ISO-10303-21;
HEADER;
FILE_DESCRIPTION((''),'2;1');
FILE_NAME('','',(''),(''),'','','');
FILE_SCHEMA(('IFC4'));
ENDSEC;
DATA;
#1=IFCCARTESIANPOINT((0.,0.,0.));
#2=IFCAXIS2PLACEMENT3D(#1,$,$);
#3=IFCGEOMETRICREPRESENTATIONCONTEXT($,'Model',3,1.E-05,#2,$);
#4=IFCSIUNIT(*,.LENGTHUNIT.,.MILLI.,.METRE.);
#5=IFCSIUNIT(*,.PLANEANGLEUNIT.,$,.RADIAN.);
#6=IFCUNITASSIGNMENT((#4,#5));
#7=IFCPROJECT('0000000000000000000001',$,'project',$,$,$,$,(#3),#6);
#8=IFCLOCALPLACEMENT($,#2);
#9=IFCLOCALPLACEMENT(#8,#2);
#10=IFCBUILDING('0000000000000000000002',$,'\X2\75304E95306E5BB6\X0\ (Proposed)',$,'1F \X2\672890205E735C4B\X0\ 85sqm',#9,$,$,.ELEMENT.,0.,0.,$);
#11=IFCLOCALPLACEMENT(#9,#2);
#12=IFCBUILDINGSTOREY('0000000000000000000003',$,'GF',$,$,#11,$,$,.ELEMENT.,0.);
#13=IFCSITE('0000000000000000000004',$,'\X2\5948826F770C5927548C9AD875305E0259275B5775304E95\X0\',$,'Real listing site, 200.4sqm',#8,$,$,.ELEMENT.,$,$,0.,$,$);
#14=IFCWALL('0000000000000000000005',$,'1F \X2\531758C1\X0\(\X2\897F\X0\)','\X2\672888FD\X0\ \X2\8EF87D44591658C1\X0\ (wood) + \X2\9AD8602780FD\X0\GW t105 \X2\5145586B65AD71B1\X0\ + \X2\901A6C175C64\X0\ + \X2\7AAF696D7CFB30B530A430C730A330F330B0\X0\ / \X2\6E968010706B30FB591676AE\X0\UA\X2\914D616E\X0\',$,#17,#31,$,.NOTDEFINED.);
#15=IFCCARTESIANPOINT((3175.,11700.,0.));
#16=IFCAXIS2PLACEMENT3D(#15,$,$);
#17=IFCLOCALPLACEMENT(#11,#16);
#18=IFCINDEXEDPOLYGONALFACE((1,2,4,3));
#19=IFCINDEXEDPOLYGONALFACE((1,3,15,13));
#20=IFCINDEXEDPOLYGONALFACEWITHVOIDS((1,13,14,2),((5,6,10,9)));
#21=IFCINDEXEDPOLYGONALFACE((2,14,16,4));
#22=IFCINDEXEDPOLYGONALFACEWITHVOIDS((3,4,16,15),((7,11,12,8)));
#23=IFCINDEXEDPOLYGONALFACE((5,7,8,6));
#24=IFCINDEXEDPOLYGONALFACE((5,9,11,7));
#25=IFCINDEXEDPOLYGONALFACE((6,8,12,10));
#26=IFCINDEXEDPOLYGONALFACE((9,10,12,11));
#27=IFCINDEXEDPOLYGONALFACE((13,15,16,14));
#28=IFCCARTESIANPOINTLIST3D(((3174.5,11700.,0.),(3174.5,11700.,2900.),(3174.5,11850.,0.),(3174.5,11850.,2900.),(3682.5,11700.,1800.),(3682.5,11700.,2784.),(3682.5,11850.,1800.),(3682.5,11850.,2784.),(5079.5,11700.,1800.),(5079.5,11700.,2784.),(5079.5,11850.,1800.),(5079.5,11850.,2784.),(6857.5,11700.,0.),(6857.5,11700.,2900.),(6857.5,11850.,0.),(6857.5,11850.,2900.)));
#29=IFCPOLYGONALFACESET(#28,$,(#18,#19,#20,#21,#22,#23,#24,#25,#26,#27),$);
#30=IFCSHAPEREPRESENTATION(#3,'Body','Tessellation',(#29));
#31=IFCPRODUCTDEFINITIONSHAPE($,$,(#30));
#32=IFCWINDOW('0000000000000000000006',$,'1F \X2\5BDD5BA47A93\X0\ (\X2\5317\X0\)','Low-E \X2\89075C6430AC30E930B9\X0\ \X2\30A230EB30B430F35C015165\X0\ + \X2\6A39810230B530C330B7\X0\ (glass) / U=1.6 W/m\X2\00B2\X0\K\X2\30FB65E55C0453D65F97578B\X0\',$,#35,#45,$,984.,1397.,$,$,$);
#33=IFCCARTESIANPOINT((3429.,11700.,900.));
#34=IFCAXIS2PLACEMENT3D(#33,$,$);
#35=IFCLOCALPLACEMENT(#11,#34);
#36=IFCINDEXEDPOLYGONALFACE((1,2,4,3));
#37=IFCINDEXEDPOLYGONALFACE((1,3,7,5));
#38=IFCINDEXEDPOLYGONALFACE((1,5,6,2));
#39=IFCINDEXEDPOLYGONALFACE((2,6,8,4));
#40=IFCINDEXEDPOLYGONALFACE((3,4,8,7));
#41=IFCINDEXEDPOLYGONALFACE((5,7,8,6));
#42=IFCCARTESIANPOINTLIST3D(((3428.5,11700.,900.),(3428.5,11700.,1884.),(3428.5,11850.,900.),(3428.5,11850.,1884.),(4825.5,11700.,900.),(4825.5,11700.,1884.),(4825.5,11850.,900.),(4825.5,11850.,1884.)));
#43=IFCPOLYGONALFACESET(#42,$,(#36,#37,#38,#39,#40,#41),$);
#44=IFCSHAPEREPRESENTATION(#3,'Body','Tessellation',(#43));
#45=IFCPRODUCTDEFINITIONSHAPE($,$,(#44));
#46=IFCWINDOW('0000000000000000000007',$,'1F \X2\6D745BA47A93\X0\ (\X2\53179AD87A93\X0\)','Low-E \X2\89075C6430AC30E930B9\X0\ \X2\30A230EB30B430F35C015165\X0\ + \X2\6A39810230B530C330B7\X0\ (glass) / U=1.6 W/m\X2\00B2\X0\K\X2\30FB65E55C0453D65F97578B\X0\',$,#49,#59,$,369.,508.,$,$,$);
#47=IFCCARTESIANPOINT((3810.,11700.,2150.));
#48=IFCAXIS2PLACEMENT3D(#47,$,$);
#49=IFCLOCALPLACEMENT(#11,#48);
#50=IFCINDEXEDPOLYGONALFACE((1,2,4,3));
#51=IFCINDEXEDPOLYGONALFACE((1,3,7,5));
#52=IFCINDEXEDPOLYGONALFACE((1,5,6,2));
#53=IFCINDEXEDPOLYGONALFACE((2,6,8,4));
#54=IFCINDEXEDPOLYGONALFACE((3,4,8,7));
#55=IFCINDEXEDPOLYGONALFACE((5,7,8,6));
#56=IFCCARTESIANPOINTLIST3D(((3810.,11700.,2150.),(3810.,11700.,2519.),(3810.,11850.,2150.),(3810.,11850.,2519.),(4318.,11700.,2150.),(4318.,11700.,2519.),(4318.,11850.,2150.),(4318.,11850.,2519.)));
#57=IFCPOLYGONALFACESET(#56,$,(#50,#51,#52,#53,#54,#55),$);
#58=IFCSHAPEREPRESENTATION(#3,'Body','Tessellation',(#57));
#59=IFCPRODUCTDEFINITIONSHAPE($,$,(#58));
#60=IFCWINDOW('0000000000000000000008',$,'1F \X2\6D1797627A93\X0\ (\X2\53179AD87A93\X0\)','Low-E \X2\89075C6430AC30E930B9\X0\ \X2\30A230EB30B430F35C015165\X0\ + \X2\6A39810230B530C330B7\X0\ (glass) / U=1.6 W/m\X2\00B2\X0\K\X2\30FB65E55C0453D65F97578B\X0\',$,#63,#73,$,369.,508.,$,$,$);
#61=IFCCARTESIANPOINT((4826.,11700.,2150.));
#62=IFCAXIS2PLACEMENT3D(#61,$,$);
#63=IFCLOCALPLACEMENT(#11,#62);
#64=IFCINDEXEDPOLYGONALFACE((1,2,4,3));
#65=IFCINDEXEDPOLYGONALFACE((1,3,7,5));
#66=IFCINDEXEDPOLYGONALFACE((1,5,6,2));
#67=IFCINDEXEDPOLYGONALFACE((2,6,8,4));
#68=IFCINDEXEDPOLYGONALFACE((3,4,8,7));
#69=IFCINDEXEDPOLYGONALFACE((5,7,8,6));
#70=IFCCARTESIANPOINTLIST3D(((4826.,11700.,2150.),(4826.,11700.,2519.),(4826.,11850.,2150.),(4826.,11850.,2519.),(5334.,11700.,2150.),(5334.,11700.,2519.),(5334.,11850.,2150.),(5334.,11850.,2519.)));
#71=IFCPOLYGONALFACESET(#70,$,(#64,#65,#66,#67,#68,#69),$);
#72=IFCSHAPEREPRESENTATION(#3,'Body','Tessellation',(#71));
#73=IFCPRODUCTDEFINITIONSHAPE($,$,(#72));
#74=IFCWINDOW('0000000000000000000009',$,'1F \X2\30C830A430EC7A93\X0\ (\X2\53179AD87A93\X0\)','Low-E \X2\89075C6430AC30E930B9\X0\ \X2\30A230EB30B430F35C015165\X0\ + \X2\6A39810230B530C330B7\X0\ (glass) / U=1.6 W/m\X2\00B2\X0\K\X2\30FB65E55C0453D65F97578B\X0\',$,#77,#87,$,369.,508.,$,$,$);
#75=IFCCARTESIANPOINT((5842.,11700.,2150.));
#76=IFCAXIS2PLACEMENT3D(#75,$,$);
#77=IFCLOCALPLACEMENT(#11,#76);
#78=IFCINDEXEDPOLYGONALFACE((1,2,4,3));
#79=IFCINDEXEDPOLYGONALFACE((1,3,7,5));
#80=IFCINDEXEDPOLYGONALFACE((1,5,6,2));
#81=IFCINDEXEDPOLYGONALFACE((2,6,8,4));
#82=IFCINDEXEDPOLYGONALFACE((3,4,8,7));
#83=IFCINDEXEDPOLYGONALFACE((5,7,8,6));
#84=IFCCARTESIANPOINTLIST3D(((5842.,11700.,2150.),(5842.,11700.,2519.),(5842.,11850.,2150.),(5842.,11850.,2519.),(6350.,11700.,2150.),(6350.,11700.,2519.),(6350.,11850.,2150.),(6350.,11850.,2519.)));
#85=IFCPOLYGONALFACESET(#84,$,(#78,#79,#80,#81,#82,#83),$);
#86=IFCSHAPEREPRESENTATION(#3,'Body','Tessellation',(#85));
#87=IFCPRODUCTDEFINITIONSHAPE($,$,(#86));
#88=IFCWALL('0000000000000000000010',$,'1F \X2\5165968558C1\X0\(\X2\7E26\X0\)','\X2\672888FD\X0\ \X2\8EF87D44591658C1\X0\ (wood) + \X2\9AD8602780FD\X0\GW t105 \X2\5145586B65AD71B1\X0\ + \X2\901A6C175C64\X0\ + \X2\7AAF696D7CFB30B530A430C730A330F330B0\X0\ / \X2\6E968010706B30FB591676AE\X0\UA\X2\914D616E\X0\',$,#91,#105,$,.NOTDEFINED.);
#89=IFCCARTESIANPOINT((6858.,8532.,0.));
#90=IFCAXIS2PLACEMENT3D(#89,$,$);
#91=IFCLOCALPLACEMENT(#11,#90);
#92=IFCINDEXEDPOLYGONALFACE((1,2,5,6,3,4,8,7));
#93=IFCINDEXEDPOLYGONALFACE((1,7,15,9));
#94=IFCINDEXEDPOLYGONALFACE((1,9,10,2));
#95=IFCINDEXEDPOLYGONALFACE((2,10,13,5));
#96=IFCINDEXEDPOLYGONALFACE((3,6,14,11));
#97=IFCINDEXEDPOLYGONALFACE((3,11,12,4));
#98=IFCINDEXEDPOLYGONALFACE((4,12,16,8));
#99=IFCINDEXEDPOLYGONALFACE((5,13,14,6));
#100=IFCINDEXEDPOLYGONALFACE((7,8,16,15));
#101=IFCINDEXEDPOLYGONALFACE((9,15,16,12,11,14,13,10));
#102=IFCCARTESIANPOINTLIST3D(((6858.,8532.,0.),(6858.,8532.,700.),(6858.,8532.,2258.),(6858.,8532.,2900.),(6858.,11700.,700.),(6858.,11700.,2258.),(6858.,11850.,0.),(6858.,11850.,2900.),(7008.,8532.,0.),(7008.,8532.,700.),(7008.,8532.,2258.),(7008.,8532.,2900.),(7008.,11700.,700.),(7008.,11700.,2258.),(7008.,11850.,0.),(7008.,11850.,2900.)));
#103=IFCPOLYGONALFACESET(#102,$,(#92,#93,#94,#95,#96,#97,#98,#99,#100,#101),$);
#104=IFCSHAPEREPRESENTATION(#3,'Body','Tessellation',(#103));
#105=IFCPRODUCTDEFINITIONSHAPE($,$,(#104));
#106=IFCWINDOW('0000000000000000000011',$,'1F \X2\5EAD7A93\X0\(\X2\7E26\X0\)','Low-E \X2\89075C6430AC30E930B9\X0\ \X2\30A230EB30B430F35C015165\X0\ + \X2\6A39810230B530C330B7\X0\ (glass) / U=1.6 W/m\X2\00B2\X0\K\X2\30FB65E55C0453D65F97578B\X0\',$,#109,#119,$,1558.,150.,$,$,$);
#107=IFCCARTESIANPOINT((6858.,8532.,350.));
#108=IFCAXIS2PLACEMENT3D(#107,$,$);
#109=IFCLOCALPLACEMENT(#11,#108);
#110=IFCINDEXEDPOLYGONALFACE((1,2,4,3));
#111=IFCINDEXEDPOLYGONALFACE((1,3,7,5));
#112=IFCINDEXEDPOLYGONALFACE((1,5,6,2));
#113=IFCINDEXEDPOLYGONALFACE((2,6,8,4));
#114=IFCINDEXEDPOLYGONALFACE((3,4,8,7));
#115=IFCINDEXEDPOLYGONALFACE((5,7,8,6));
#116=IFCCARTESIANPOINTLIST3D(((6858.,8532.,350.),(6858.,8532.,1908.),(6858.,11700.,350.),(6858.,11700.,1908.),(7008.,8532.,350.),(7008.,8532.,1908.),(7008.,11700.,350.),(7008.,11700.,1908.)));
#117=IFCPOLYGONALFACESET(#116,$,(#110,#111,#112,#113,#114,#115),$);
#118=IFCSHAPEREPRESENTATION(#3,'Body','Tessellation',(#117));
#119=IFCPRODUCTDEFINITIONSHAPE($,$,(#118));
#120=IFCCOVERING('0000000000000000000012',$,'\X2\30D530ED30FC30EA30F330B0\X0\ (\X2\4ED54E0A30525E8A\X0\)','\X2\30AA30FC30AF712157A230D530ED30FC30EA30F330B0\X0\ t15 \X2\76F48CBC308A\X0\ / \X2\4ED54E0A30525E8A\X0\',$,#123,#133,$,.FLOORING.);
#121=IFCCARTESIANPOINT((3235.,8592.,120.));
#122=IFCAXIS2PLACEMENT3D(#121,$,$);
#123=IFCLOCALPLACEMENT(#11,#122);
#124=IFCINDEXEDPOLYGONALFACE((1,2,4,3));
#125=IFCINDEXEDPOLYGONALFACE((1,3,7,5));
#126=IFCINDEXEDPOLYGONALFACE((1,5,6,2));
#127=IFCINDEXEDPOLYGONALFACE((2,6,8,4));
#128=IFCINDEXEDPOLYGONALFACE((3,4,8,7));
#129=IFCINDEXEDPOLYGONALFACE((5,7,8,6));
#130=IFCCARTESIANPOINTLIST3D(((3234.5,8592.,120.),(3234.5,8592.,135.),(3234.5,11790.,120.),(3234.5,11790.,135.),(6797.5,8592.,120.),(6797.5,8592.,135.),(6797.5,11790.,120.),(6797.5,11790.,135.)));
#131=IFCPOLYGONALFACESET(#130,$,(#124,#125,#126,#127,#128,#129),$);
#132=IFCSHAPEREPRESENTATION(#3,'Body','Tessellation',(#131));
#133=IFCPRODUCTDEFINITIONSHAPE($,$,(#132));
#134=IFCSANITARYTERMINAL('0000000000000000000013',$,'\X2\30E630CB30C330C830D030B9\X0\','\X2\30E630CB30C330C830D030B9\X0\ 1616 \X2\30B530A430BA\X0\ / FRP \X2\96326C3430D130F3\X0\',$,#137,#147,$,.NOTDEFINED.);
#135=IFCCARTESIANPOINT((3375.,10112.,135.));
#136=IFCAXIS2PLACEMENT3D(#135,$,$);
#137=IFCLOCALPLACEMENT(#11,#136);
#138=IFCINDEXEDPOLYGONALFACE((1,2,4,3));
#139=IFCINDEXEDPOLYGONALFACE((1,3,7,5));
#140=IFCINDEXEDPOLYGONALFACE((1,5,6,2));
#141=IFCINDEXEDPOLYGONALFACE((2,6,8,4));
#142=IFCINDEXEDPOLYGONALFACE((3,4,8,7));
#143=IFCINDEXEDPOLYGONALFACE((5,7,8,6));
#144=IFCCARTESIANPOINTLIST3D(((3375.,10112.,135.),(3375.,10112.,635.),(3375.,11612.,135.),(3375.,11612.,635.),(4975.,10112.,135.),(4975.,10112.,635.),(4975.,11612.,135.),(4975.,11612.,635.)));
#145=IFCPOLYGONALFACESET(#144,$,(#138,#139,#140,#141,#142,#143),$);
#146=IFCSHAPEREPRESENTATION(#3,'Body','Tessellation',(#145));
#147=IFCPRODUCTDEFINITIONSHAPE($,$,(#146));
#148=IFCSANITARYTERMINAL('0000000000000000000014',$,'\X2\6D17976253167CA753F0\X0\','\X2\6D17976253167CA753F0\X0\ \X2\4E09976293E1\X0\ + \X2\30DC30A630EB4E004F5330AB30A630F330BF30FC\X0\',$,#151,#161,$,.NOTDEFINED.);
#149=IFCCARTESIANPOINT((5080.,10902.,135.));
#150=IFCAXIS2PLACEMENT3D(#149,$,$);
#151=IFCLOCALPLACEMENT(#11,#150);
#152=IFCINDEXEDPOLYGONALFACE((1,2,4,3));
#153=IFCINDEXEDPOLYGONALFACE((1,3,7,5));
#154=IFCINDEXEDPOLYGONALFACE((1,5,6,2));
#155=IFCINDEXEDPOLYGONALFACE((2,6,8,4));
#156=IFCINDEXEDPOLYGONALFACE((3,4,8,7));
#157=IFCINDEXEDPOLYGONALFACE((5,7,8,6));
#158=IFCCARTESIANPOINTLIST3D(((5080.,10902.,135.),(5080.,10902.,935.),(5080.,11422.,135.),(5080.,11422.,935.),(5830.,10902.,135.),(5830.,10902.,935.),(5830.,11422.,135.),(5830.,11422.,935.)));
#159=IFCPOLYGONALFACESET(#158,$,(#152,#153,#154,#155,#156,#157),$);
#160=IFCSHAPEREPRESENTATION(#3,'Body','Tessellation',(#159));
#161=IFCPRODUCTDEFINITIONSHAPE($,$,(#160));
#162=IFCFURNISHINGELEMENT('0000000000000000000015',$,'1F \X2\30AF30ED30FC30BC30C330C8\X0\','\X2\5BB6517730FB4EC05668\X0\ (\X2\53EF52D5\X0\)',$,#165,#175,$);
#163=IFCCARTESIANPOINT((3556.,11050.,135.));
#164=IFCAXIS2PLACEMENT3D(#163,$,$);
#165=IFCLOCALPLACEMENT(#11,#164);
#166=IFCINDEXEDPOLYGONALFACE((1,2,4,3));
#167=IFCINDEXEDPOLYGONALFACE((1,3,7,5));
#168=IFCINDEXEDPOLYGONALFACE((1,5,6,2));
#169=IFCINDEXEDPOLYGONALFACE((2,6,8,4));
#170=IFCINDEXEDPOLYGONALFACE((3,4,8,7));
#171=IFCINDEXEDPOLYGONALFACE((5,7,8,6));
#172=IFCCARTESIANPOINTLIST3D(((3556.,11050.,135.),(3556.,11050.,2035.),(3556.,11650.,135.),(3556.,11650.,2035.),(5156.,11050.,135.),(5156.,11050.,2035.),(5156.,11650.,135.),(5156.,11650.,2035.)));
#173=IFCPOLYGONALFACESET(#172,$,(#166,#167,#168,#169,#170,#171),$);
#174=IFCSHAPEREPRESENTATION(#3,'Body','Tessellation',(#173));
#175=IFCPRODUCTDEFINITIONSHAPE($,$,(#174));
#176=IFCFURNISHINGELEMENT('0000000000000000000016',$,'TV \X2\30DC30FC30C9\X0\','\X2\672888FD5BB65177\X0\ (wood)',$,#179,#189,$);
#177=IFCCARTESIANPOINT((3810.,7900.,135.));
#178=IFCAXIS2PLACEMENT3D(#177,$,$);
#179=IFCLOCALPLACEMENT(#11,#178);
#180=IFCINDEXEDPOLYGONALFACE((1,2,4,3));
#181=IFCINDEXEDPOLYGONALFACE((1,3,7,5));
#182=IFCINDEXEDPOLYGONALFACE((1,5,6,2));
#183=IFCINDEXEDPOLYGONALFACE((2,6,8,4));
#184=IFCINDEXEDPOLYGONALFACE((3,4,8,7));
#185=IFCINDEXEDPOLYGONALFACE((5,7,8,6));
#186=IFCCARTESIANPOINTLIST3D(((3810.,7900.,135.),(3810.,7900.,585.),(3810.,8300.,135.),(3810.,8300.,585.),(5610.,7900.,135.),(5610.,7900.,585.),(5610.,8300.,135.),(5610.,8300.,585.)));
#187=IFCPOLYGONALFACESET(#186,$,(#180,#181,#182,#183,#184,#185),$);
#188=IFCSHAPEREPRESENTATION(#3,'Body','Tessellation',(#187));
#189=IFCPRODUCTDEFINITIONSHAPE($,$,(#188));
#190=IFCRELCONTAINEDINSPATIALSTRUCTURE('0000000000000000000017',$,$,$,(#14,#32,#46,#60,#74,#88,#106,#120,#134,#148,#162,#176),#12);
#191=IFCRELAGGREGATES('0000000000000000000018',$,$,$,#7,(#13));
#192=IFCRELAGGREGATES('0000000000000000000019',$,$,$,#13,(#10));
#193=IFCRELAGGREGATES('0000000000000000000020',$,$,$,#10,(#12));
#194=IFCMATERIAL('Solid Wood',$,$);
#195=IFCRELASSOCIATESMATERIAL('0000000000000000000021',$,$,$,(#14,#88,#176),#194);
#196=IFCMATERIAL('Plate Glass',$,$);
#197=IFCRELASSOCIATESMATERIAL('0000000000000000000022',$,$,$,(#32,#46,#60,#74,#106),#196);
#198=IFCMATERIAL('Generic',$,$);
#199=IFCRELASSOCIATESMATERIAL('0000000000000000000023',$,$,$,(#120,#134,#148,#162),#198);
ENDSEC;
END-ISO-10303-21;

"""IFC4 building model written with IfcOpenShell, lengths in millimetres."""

from ifc_helpers import new_model, si_unit, frame, frame_2d, origin, place, context, project, spatial, rectangle, extrude, material, element, fill, save


model = new_model("IFC4")

# Units and contexts
model_context = context("Model", 3, precision=1e-05, world=origin())
ifc_project = project(units=[si_unit("LENGTHUNIT", "METRE", prefix="MILLI"), si_unit("PLANEANGLEUNIT", "RADIAN")], contexts=[model_context])

# Site, building, storey
site_placement = place(None, origin())
site = spatial("IfcSite", under=ifc_project, at=site_placement, Name="奈良県大和高田市大字田井", ObjectType="Real listing site, 200.4sqm", CompositionType="ELEMENT", RefElevation=0.0)
building_placement = place(site_placement, origin())
building = spatial("IfcBuilding", under=site, at=building_placement, Name="田井の家 (Proposed)", ObjectType="1F 木造平屋 85sqm", CompositionType="ELEMENT", ElevationOfRefHeight=0.0, ElevationOfTerrain=0.0)
storey_placement = place(building_placement, origin())
storey = spatial("IfcBuildingStorey", under=building, at=storey_placement, Name="GF", CompositionType="ELEMENT", Elevation=0.0)

# Shared definitions
ifc_material_1 = material(Name="Solid Wood")

# Wall, openings, windows
wall_1_placement = place(storey_placement, frame((3175.0, 11700.0, 0.0)))
wall_1 = element("IfcWall", 1, at=wall_1_placement, inside=storey, material=ifc_material_1, Name="1F 北壁(西)", Description="木製 軸組外壁 (wood) + 高性能GW t105 充填断熱 + 通気層 + 窯業系サイディング / 準耐火・外皮UA配慮", PredefinedType="NOTDEFINED", context=model_context, shape_type="SweptSolid", body=[
    extrude(rectangle(XDim=3683.0, YDim=150.0, at=frame_2d((1841.0, 75.0))), frame((3175.0, 11700.0, 0.0)), (0.0, 0.0, 1.0), 2900.0),
])
opening_1_placement = place(storey_placement, frame((3429.0, 11700.0, 900.0)))
opening_1 = element("IfcOpeningElement", 2, at=opening_1_placement, cuts=wall_1, PredefinedType="NOTDEFINED", context=model_context, shape_type="SweptSolid", body=[
    extrude(rectangle(XDim=1397.0, YDim=150.0, at=frame_2d((698.0, 75.0))), frame((3429.0, 11700.0, 900.0)), (0.0, 0.0, 1.0), 984.0),
])
opening_2_placement = place(storey_placement, frame((3810.0, 11700.0, 2150.0)))
opening_2 = element("IfcOpeningElement", 3, at=opening_2_placement, cuts=wall_1, PredefinedType="NOTDEFINED", context=model_context, shape_type="SweptSolid", body=[
    extrude(rectangle(XDim=508.0, YDim=150.0, at=frame_2d((254.0, 75.0))), frame((3810.0, 11700.0, 2150.0)), (0.0, 0.0, 1.0), 369.0),
])
opening_3_placement = place(storey_placement, frame((4826.0, 11700.0, 2150.0)))
opening_3 = element("IfcOpeningElement", 4, at=opening_3_placement, cuts=wall_1, PredefinedType="NOTDEFINED", context=model_context, shape_type="SweptSolid", body=[
    extrude(rectangle(XDim=508.0, YDim=150.0, at=frame_2d((254.0, 75.0))), frame((4826.0, 11700.0, 2150.0)), (0.0, 0.0, 1.0), 369.0),
])
opening_4_placement = place(storey_placement, frame((5842.0, 11700.0, 2150.0)))
opening_4 = element("IfcOpeningElement", 5, at=opening_4_placement, cuts=wall_1, PredefinedType="NOTDEFINED", context=model_context, shape_type="SweptSolid", body=[
    extrude(rectangle(XDim=508.0, YDim=150.0, at=frame_2d((254.0, 75.0))), frame((5842.0, 11700.0, 2150.0)), (0.0, 0.0, 1.0), 369.0),
])
ifc_material_2 = material(Name="Plate Glass")
window_1_placement = place(storey_placement, frame((3429.0, 11700.0, 900.0)))
window_1 = element("IfcWindow", 6, at=window_1_placement, inside=storey, material=ifc_material_2, Name="1F 寝室窓 (北)", Description="Low-E 複層ガラス アルゴン封入 + 樹脂サッシ (glass) / U=1.6 W/m²K・日射取得型", OverallHeight=984.0, OverallWidth=1397.0, context=model_context, shape_type="SweptSolid", body=[
    extrude(rectangle(XDim=1397.0, YDim=150.0, at=frame_2d((698.0, 75.0))), frame((3429.0, 11700.0, 900.0)), (0.0, 0.0, 1.0), 984.0),
])
fill(opening_1, window_1)
window_2_placement = place(storey_placement, frame((3810.0, 11700.0, 2150.0)))
window_2 = element("IfcWindow", 7, at=window_2_placement, inside=storey, material=ifc_material_2, Name="1F 浴室窓 (北高窓)", Description="Low-E 複層ガラス アルゴン封入 + 樹脂サッシ (glass) / U=1.6 W/m²K・日射取得型", OverallHeight=369.0, OverallWidth=508.0, context=model_context, shape_type="SweptSolid", body=[
    extrude(rectangle(XDim=508.0, YDim=150.0, at=frame_2d((254.0, 75.0))), frame((3810.0, 11700.0, 2150.0)), (0.0, 0.0, 1.0), 369.0),
])
fill(opening_2, window_2)
window_3_placement = place(storey_placement, frame((4826.0, 11700.0, 2150.0)))
window_3 = element("IfcWindow", 8, at=window_3_placement, inside=storey, material=ifc_material_2, Name="1F 洗面窓 (北高窓)", Description="Low-E 複層ガラス アルゴン封入 + 樹脂サッシ (glass) / U=1.6 W/m²K・日射取得型", OverallHeight=369.0, OverallWidth=508.0, context=model_context, shape_type="SweptSolid", body=[
    extrude(rectangle(XDim=508.0, YDim=150.0, at=frame_2d((254.0, 75.0))), frame((4826.0, 11700.0, 2150.0)), (0.0, 0.0, 1.0), 369.0),
])
fill(opening_3, window_3)
window_4_placement = place(storey_placement, frame((5842.0, 11700.0, 2150.0)))
window_4 = element("IfcWindow", 9, at=window_4_placement, inside=storey, material=ifc_material_2, Name="1F トイレ窓 (北高窓)", Description="Low-E 複層ガラス アルゴン封入 + 樹脂サッシ (glass) / U=1.6 W/m²K・日射取得型", OverallHeight=369.0, OverallWidth=508.0, context=model_context, shape_type="SweptSolid", body=[
    extrude(rectangle(XDim=508.0, YDim=150.0, at=frame_2d((254.0, 75.0))), frame((5842.0, 11700.0, 2150.0)), (0.0, 0.0, 1.0), 369.0),
])
fill(opening_4, window_4)

# Wall, opening, window
wall_2_placement = place(storey_placement, frame((6858.0, 8532.0, 0.0)))
wall_2 = element("IfcWall", 10, at=wall_2_placement, inside=storey, material=ifc_material_1, Name="1F 入隅壁(縦)", Description="木製 軸組外壁 (wood) + 高性能GW t105 充填断熱 + 通気層 + 窯業系サイディング / 準耐火・外皮UA配慮", PredefinedType="NOTDEFINED", context=model_context, shape_type="SweptSolid", body=[
    extrude(rectangle(XDim=150.0, YDim=3318.0, at=frame_2d((75.0, 1659.0))), frame((6858.0, 8532.0, 0.0)), (0.0, 0.0, 1.0), 2900.0),
])
opening_5_placement = place(storey_placement, frame((6858.0, 8532.0, 350.0)))
opening_5 = element("IfcOpeningElement", 11, at=opening_5_placement, cuts=wall_2, PredefinedType="NOTDEFINED", context=model_context, shape_type="SweptSolid", body=[
    extrude(rectangle(XDim=150.0, YDim=3168.0, at=frame_2d((75.0, 1584.0))), frame((6858.0, 8532.0, 350.0)), (0.0, 0.0, 1.0), 1558.0),
])
window_5_placement = place(storey_placement, frame((6858.0, 8532.0, 350.0)))
window_5 = element("IfcWindow", 12, at=window_5_placement, inside=storey, material=ifc_material_2, Name="1F 庭窓(縦)", Description="Low-E 複層ガラス アルゴン封入 + 樹脂サッシ (glass) / U=1.6 W/m²K・日射取得型", OverallHeight=1558.0, OverallWidth=150.0, context=model_context, shape_type="SweptSolid", body=[
    extrude(rectangle(XDim=150.0, YDim=3168.0, at=frame_2d((75.0, 1584.0))), frame((6858.0, 8532.0, 350.0)), (0.0, 0.0, 1.0), 1558.0),
])
fill(opening_5, window_5)

# Covering
ifc_material_3 = material(Name="Generic")
covering_placement = place(storey_placement, frame((3235.0, 8592.0, 120.0)))
element("IfcCovering", 13, at=covering_placement, inside=storey, material=ifc_material_3, Name="フローリング (仕上げ床)", Description="オーク無垢フローリング t15 直貼り / 仕上げ床", PredefinedType="FLOORING", context=model_context, shape_type="SweptSolid", body=[
    extrude(rectangle(XDim=3563.0, YDim=3198.0, at=frame_2d((1781.0, 1599.0))), frame((3235.0, 8592.0, 120.0)), (0.0, 0.0, 1.0), 15.0),
])

# Sanitary terminals
sanitary_terminal_1_placement = place(storey_placement, frame((3375.0, 10112.0, 135.0)))
element("IfcSanitaryTerminal", 14, at=sanitary_terminal_1_placement, inside=storey, material=ifc_material_3, Name="ユニットバス", Description="ユニットバス 1616 サイズ / FRP 防水パン", PredefinedType="NOTDEFINED", context=model_context, shape_type="SweptSolid", body=[
    extrude(rectangle(XDim=1600.0, YDim=1500.0, at=frame_2d((800.0, 750.0))), frame((3375.0, 10112.0, 135.0)), (0.0, 0.0, 1.0), 500.0),
])
sanitary_terminal_2_placement = place(storey_placement, frame((5080.0, 10902.0, 135.0)))
element("IfcSanitaryTerminal", 15, at=sanitary_terminal_2_placement, inside=storey, material=ifc_material_3, Name="洗面化粧台", Description="洗面化粧台 三面鏡 + ボウル一体カウンター", PredefinedType="NOTDEFINED", context=model_context, shape_type="SweptSolid", body=[
    extrude(rectangle(XDim=750.0, YDim=520.0, at=frame_2d((375.0, 260.0))), frame((5080.0, 10902.0, 135.0)), (0.0, 0.0, 1.0), 800.0),
])

# Furnishing elements
furnishing_1_placement = place(storey_placement, frame((3556.0, 11050.0, 135.0)))
element("IfcFurnishingElement", 16, at=furnishing_1_placement, inside=storey, material=ifc_material_3, Name="1F クローゼット", Description="家具・什器 (可動)", context=model_context, shape_type="SweptSolid", body=[
    extrude(rectangle(XDim=1600.0, YDim=600.0, at=frame_2d((800.0, 300.0))), frame((3556.0, 11050.0, 135.0)), (0.0, 0.0, 1.0), 1900.0),
])
furnishing_2_placement = place(storey_placement, frame((3810.0, 7900.0, 135.0)))
element("IfcFurnishingElement", 17, at=furnishing_2_placement, inside=storey, material=ifc_material_1, Name="TV ボード", Description="木製家具 (wood)", context=model_context, shape_type="SweptSolid", body=[
    extrude(rectangle(XDim=1800.0, YDim=400.0, at=frame_2d((900.0, 200.0))), frame((3810.0, 7900.0, 135.0)), (0.0, 0.0, 1.0), 450.0),
])

save(model, "model.ifc")
